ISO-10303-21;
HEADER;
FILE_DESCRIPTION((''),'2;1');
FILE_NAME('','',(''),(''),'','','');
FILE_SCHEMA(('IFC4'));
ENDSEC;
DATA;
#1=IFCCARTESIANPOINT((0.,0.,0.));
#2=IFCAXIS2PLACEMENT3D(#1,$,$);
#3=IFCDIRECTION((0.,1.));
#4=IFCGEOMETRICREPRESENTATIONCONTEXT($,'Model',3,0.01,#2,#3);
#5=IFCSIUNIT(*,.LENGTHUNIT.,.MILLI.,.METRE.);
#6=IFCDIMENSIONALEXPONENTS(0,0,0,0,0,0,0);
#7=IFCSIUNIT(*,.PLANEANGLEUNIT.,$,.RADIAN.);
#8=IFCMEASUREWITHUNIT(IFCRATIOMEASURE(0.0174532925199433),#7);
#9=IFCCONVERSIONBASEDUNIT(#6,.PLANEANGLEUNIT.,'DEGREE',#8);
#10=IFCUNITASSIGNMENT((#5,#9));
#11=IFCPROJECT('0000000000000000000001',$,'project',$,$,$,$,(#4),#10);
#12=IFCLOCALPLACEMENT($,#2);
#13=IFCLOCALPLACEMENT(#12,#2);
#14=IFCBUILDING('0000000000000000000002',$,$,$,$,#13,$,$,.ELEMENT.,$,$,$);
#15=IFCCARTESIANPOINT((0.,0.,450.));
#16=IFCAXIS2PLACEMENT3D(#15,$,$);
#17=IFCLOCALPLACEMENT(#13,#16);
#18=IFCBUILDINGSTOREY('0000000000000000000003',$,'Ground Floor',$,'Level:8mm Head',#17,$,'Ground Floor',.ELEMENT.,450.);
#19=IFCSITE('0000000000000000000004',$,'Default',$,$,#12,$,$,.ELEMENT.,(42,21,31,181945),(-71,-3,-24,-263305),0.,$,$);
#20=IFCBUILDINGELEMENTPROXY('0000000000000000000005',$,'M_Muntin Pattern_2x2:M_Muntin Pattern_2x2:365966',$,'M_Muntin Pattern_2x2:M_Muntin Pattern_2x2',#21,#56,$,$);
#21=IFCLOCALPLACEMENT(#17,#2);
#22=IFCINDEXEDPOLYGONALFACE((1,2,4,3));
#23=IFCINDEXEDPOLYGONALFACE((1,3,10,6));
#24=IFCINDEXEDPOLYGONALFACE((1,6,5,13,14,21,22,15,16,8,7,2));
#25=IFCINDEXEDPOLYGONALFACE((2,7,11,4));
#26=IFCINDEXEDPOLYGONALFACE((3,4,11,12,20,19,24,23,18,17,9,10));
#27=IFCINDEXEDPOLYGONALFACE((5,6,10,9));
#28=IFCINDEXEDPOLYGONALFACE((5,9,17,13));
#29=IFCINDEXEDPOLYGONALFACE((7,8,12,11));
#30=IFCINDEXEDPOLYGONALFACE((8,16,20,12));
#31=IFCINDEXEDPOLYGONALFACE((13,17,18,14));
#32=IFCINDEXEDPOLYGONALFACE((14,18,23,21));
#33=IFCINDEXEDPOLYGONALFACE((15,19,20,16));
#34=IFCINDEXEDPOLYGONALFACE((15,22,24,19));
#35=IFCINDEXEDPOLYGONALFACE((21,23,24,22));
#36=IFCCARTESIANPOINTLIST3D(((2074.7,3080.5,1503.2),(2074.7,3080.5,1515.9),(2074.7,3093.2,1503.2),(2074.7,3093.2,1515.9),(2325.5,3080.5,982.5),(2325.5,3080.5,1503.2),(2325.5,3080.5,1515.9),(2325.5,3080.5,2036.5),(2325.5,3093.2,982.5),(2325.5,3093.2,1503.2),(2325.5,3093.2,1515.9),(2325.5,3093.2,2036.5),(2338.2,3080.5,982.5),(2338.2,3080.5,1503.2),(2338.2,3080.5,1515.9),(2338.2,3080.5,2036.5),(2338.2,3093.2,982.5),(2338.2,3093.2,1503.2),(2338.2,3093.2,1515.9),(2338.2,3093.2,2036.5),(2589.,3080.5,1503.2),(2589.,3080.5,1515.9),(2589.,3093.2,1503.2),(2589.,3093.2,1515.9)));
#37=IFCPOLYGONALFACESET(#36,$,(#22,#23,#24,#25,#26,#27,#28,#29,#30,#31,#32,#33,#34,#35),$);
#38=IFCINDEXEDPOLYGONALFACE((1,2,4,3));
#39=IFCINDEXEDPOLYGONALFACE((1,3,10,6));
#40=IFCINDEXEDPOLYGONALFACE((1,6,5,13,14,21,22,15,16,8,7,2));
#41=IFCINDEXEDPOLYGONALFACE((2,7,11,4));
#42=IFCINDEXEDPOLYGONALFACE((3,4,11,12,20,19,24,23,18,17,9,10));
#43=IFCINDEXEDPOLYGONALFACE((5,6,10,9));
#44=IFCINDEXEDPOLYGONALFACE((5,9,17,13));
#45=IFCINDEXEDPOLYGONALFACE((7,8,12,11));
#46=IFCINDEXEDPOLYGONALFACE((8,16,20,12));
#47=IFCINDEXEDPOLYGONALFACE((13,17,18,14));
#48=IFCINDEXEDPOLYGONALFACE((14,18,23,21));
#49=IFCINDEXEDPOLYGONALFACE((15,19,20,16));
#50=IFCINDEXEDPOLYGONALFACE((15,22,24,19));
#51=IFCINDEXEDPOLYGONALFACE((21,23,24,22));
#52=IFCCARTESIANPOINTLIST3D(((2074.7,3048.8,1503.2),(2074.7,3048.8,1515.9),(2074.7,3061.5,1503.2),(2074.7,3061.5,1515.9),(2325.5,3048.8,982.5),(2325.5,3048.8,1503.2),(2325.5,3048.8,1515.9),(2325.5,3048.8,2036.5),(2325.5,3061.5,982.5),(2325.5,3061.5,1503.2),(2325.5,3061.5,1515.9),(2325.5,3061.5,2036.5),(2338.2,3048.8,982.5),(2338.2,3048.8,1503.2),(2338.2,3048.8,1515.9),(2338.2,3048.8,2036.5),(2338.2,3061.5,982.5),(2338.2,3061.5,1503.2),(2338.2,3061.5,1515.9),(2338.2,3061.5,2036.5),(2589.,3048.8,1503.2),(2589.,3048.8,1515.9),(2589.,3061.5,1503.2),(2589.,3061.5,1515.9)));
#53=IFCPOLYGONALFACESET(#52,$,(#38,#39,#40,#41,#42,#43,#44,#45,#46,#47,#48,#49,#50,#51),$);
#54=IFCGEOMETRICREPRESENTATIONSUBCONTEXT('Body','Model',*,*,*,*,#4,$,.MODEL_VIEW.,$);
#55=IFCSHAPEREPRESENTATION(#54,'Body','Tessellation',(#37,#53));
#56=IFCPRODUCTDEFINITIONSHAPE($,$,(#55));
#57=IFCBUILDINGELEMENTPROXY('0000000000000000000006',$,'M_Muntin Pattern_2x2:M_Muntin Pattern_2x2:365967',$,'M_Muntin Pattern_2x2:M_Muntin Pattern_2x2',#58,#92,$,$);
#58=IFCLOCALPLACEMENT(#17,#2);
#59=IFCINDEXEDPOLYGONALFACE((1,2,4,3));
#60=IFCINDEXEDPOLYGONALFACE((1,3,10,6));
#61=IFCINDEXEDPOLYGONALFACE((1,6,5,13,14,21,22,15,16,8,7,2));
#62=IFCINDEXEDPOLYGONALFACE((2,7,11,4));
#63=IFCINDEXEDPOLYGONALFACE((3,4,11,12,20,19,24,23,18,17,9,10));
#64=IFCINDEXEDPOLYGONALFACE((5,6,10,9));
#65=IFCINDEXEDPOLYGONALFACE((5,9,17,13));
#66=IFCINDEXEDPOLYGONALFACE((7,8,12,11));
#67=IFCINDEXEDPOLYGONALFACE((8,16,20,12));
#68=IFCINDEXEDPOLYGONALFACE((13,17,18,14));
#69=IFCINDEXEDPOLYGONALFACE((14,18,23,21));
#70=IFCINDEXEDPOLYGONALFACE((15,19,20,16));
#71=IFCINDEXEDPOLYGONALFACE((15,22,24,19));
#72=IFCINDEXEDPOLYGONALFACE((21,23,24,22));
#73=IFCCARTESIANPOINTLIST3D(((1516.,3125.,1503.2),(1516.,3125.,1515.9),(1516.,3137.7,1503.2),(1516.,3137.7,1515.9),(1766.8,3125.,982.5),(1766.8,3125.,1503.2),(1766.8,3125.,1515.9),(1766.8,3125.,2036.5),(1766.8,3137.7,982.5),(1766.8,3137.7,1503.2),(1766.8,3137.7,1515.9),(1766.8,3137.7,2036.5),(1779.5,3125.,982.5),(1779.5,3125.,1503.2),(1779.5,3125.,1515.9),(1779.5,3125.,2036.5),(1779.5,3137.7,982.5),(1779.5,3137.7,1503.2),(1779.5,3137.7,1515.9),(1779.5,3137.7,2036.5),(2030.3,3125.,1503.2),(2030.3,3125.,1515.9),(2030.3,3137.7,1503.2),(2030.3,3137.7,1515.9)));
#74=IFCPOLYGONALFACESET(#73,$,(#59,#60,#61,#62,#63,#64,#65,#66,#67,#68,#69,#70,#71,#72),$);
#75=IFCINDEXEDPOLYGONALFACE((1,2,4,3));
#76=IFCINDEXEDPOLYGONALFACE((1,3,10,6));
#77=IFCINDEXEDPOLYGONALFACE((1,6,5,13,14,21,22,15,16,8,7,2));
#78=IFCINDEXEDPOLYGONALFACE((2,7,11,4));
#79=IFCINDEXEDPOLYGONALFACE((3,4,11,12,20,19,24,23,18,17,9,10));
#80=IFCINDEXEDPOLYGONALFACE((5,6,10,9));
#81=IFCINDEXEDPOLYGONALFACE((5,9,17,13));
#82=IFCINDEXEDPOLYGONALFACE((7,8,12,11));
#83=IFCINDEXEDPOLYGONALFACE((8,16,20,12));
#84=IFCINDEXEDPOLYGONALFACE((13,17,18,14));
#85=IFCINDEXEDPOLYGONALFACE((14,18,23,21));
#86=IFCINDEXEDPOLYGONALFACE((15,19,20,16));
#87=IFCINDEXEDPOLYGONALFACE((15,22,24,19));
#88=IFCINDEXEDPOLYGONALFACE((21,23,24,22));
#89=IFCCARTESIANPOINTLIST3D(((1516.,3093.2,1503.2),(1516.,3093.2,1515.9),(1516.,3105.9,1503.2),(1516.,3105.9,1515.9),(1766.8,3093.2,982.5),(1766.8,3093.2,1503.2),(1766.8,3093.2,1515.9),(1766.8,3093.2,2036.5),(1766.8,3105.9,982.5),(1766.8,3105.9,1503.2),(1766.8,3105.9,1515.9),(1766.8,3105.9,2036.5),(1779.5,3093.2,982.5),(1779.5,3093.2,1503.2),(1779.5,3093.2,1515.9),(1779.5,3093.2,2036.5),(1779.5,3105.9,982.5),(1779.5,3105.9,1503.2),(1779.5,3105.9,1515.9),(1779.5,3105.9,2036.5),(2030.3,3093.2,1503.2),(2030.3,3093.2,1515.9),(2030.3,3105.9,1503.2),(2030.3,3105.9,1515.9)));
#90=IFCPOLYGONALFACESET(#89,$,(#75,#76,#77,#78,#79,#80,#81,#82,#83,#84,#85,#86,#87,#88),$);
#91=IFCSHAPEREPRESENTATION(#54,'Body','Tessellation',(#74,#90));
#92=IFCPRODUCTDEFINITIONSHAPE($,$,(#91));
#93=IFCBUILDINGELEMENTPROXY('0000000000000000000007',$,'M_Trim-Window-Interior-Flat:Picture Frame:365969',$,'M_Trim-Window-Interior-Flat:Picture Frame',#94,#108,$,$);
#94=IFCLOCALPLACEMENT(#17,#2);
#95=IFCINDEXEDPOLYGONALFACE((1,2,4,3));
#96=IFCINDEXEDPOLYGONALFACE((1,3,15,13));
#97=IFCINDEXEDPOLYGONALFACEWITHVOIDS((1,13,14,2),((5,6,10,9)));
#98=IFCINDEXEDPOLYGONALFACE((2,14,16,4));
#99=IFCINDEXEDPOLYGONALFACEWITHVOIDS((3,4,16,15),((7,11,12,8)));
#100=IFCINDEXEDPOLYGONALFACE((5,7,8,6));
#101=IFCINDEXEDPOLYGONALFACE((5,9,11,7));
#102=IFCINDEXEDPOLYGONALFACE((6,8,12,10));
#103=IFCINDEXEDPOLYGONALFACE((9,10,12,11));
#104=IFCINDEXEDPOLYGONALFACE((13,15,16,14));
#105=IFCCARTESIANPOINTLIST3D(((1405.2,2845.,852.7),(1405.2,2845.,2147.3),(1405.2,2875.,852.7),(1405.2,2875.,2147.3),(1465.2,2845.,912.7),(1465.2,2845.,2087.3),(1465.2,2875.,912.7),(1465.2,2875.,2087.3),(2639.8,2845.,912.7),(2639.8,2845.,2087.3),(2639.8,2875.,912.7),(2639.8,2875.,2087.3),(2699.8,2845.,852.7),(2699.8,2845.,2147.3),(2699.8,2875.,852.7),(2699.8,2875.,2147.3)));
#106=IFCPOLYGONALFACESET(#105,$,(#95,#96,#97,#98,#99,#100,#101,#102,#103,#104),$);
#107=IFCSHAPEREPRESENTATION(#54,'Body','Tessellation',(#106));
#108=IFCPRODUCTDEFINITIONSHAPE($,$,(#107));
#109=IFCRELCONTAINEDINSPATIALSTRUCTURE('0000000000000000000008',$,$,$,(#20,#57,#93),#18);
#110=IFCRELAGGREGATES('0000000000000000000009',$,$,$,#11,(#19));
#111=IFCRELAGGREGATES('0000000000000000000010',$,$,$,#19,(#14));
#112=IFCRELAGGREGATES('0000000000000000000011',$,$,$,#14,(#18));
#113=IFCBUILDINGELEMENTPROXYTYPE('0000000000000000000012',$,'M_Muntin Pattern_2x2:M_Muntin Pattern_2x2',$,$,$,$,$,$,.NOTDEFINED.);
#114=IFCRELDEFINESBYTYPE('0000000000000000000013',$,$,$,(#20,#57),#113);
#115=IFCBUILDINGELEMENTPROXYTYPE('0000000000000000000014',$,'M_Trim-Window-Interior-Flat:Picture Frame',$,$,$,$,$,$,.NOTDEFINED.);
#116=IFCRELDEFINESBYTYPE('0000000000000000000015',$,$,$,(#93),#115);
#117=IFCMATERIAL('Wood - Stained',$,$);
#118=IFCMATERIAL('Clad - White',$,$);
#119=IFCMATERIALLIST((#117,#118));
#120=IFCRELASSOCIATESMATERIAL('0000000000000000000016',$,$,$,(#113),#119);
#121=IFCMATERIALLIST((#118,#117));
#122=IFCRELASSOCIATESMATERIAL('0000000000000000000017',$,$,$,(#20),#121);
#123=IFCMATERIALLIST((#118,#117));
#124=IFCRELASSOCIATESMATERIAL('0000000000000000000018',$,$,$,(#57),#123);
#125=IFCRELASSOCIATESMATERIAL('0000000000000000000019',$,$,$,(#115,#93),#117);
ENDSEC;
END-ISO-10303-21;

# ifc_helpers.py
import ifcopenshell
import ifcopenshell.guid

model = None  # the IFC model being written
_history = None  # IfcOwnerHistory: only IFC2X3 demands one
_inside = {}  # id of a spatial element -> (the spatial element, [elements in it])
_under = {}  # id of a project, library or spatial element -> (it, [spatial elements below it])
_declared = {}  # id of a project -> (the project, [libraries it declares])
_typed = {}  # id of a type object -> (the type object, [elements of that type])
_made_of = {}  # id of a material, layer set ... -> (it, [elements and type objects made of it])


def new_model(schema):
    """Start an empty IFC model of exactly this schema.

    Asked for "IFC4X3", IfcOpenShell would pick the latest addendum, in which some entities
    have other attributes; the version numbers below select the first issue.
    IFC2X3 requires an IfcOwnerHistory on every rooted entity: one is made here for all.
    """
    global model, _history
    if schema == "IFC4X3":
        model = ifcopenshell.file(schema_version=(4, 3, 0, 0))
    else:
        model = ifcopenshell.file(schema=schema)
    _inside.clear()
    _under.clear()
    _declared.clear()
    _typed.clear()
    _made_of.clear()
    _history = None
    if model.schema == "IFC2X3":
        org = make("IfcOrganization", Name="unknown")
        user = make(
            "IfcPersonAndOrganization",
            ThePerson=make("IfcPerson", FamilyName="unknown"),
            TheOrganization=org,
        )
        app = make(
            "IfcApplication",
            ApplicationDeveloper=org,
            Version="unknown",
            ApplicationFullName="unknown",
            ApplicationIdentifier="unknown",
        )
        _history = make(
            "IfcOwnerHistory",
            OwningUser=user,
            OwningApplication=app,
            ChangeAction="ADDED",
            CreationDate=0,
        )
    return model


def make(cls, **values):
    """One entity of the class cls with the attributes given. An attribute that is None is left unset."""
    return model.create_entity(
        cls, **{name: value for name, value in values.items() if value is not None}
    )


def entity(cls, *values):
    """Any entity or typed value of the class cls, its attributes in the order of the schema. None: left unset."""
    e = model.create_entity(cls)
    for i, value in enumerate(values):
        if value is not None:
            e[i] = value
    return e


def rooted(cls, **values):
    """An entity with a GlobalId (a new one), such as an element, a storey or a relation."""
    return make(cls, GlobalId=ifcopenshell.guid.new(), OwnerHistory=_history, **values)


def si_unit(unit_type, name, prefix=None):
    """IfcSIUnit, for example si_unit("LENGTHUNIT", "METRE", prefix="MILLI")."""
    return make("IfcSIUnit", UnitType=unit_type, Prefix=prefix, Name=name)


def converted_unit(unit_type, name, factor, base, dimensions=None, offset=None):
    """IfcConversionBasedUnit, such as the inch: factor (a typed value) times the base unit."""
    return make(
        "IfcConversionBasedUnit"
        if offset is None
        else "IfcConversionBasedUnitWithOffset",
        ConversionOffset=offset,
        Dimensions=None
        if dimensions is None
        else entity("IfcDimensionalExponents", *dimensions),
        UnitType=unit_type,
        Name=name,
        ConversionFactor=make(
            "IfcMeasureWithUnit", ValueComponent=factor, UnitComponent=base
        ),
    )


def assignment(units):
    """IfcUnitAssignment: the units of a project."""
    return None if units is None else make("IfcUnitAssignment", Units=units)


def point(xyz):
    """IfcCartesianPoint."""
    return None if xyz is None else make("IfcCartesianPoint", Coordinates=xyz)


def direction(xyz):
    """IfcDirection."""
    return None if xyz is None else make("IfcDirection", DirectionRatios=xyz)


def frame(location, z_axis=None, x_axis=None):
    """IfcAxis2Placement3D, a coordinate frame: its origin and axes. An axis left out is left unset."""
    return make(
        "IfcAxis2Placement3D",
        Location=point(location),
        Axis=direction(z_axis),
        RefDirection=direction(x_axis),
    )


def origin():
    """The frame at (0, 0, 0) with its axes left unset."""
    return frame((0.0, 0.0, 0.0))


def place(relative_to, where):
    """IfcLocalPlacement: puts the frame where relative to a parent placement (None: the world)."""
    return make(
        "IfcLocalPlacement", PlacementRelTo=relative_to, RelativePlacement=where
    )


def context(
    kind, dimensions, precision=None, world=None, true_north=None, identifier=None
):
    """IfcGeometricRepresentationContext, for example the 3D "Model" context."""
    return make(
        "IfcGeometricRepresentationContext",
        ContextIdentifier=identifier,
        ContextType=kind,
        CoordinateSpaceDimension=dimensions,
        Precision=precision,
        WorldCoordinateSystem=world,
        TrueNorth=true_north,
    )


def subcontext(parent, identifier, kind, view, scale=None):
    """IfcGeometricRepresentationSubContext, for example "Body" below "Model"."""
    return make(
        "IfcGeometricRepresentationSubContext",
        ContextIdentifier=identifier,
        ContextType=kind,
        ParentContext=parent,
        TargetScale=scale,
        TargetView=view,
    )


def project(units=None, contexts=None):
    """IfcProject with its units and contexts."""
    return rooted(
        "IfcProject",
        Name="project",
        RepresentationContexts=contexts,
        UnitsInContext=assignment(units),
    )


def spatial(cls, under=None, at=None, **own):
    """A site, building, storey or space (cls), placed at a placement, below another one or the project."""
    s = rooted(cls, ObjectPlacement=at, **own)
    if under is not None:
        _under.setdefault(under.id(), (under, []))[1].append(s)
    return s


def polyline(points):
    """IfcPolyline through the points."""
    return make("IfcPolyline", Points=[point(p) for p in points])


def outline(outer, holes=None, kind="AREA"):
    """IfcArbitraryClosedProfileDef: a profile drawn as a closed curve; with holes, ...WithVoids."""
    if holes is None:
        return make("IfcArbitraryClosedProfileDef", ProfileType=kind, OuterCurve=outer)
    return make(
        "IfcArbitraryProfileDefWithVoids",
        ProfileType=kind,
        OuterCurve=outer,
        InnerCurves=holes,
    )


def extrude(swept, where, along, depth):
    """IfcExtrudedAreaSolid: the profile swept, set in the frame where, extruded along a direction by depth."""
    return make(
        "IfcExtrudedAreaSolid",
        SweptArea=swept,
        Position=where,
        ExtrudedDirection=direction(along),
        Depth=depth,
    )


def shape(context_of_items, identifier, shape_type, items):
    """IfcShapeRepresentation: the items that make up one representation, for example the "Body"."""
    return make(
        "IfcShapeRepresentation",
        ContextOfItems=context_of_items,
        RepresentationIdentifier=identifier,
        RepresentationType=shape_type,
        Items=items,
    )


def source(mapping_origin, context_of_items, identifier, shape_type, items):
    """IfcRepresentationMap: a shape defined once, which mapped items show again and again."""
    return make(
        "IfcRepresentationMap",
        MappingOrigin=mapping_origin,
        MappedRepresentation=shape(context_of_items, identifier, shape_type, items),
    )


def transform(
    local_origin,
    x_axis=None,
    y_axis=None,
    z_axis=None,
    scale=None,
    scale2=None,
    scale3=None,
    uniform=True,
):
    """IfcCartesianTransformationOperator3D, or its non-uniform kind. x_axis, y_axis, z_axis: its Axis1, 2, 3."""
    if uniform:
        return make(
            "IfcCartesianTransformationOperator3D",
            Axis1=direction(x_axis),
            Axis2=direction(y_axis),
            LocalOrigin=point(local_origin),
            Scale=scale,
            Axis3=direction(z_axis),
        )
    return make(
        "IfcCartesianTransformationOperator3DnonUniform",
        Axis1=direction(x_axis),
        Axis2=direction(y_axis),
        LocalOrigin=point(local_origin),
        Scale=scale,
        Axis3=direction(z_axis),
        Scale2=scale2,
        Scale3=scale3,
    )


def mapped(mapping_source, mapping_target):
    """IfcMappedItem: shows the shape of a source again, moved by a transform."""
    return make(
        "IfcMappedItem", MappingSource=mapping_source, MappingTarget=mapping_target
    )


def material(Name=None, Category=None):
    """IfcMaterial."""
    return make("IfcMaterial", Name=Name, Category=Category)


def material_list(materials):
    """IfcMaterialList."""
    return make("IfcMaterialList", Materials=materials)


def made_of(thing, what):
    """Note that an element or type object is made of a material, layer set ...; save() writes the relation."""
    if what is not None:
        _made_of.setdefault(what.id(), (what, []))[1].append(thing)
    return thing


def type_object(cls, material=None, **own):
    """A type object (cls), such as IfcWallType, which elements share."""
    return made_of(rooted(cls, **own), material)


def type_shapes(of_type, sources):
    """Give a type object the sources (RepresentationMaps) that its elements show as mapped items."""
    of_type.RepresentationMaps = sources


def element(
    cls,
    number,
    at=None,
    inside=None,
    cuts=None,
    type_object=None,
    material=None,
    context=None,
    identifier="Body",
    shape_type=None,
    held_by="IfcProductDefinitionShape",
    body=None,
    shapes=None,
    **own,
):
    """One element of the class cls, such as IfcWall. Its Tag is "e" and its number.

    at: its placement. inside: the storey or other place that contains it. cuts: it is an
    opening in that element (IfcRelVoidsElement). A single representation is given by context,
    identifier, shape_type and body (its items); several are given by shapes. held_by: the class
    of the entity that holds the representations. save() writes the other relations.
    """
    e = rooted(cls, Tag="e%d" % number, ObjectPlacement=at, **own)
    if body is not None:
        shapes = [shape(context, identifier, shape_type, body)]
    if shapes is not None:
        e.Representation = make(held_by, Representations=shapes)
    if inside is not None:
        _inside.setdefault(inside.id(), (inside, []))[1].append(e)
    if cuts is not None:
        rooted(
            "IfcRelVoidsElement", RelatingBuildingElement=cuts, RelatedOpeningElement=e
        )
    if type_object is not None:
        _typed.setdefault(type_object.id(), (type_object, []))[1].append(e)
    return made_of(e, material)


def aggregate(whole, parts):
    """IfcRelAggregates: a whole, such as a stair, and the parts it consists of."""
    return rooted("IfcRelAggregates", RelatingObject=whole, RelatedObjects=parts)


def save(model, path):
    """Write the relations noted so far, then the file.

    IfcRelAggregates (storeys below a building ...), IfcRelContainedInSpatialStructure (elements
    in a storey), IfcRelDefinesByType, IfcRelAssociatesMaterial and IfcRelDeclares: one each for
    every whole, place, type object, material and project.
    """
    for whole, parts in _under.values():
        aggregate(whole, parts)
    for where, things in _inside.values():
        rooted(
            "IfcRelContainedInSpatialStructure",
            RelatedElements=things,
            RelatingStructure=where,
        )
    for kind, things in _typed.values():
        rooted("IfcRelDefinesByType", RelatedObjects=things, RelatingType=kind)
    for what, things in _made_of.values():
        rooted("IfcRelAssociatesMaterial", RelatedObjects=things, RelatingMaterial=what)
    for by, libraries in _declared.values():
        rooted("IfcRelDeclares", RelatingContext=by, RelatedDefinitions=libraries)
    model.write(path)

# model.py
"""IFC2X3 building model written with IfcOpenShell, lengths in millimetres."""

from ifc_helpers import new_model, entity, si_unit, converted_unit, direction, frame, origin, place, context, subcontext, project, spatial, polyline, outline, extrude, source, transform, mapped, material, material_list, type_object, type_shapes, element, save


model = new_model("IFC2X3")

# Units and contexts
model_context = context("Model", 3, precision=0.01, world=origin(), true_north=direction((0.0, 1.0)))
body_context = subcontext(model_context, "Body", "Model", "MODEL_VIEW")
ifc_project = project(units=[si_unit("LENGTHUNIT", "METRE", prefix="MILLI"), converted_unit("PLANEANGLEUNIT", "DEGREE", entity("IfcRatioMeasure", 0.0174532925199433), si_unit("PLANEANGLEUNIT", "RADIAN"), dimensions=[0, 0, 0, 0, 0, 0, 0])], contexts=[model_context])

# Site, building, storey
site_placement = place(None, origin())
site = spatial("IfcSite", under=ifc_project, at=site_placement, Name="Default", CompositionType="ELEMENT", RefLatitude=(42, 21, 31, 181945), RefLongitude=(-71, -3, -24, -263305), RefElevation=0.0)
building_placement = place(site_placement, origin())
building = spatial("IfcBuilding", under=site, at=building_placement, CompositionType="ELEMENT")
storey_placement = place(building_placement, frame((0.0, 0.0, 450.0)))
storey = spatial("IfcBuildingStorey", under=building, at=storey_placement, Name="Ground Floor", ObjectType="Level:8mm Head", LongName="Ground Floor", CompositionType="ELEMENT", Elevation=450.0)

# Building element proxies
ifc_material_1 = material(Name="Clad - White")
ifc_material_2 = material(Name="Wood - Stained")
ifc_material_list_1 = material_list([ifc_material_1, ifc_material_2])
ifc_material_list_2 = material_list([ifc_material_2, ifc_material_1])
building_element_proxy_type_1 = type_object("IfcBuildingElementProxyType", Name="M_Muntin Pattern_2x2:M_Muntin Pattern_2x2", PredefinedType="NOTDEFINED", material=ifc_material_list_2)
shared_shape_1 = source(origin(), body_context, "Body", "SweptSolid", [
    extrude(outline(polyline([(6.4, -6.4), (527.0, -6.4), (527.0, 6.3), (6.4, 6.3), (6.4, 257.1), (-6.3, 257.1), (-6.3, 6.3), (-527.0, 6.3), (-527.0, -6.4), (-6.3, -6.4), (-6.3, -257.1), (6.4, -257.1), (6.4, -6.4)])), frame((0.0, 9.5, 527.0), z_axis=(0.0, 1.0, 0.0), x_axis=(0.0, 0.0, 1.0)), (0.0, 0.0, 1.0), 12.7),
    extrude(outline(polyline([(6.4, -6.4), (527.0, -6.4), (527.0, 6.3), (6.4, 6.3), (6.4, 257.1), (-6.3, 257.1), (-6.3, 6.3), (-527.0, 6.3), (-527.0, -6.4), (-6.3, -6.4), (-6.3, -257.1), (6.4, -257.1), (6.4, -6.4)])), frame((0.0, -22.2, 527.0), z_axis=(0.0, 1.0, 0.0), x_axis=(0.0, 0.0, 1.0)), (0.0, 0.0, 1.0), 12.7),
])
type_shapes(building_element_proxy_type_1, [shared_shape_1])
proxy_1_placement = place(storey_placement, frame((2331.9, 3071.0, 982.5)))
element("IfcBuildingElementProxy", 1, at=proxy_1_placement, inside=storey, type_object=building_element_proxy_type_1, material=ifc_material_list_1, Name="M_Muntin Pattern_2x2:M_Muntin Pattern_2x2:365966", ObjectType="M_Muntin Pattern_2x2:M_Muntin Pattern_2x2", context=body_context, shape_type="MappedRepresentation", body=[
    mapped(shared_shape_1, transform((0.0, 0.0, 0.0), scale=1.0)),
])
ifc_material_list_3 = material_list([ifc_material_1, ifc_material_2])
proxy_2_placement = place(storey_placement, frame((1773.1, 3115.5, 982.5)))
element("IfcBuildingElementProxy", 2, at=proxy_2_placement, inside=storey, type_object=building_element_proxy_type_1, material=ifc_material_list_3, Name="M_Muntin Pattern_2x2:M_Muntin Pattern_2x2:365967", ObjectType="M_Muntin Pattern_2x2:M_Muntin Pattern_2x2", context=body_context, shape_type="MappedRepresentation", body=[
    mapped(shared_shape_1, transform((0.0, 0.0, 0.0), scale=1.0)),
])
building_element_proxy_type_2 = type_object("IfcBuildingElementProxyType", Name="M_Trim-Window-Interior-Flat:Picture Frame", PredefinedType="NOTDEFINED", material=ifc_material_2)
shared_shape_2 = source(origin(), body_context, "Body", "SweptSolid", [
    extrude(outline(polyline([(-647.3, -647.3), (647.3, -647.3), (647.3, 647.3), (-647.3, 647.3), (-647.3, -647.3)]), holes=[polyline([(-587.3, -587.3), (-587.3, 587.3), (587.3, 587.3), (587.3, -587.3), (-587.3, -587.3)])]), frame((0.0, -600.0, 0.0), z_axis=(0.0, 0.0, 1.0), x_axis=(-1.0, 0.0, 0.0)), (0.0, 0.0, 1.0), 30.0),
])
type_shapes(building_element_proxy_type_2, [shared_shape_2])
proxy_3_placement = place(storey_placement, frame((2052.5, 2875.0, 2100.0), z_axis=(0.0, -1.0, 0.0), x_axis=(1.0, 0.0, 0.0)))
element("IfcBuildingElementProxy", 3, at=proxy_3_placement, inside=storey, type_object=building_element_proxy_type_2, material=ifc_material_2, Name="M_Trim-Window-Interior-Flat:Picture Frame:365969", ObjectType="M_Trim-Window-Interior-Flat:Picture Frame", context=body_context, shape_type="MappedRepresentation", body=[
    mapped(shared_shape_2, transform((0.0, 0.0, 0.0), scale=1.0)),
])

save(model, "model.ifc")
